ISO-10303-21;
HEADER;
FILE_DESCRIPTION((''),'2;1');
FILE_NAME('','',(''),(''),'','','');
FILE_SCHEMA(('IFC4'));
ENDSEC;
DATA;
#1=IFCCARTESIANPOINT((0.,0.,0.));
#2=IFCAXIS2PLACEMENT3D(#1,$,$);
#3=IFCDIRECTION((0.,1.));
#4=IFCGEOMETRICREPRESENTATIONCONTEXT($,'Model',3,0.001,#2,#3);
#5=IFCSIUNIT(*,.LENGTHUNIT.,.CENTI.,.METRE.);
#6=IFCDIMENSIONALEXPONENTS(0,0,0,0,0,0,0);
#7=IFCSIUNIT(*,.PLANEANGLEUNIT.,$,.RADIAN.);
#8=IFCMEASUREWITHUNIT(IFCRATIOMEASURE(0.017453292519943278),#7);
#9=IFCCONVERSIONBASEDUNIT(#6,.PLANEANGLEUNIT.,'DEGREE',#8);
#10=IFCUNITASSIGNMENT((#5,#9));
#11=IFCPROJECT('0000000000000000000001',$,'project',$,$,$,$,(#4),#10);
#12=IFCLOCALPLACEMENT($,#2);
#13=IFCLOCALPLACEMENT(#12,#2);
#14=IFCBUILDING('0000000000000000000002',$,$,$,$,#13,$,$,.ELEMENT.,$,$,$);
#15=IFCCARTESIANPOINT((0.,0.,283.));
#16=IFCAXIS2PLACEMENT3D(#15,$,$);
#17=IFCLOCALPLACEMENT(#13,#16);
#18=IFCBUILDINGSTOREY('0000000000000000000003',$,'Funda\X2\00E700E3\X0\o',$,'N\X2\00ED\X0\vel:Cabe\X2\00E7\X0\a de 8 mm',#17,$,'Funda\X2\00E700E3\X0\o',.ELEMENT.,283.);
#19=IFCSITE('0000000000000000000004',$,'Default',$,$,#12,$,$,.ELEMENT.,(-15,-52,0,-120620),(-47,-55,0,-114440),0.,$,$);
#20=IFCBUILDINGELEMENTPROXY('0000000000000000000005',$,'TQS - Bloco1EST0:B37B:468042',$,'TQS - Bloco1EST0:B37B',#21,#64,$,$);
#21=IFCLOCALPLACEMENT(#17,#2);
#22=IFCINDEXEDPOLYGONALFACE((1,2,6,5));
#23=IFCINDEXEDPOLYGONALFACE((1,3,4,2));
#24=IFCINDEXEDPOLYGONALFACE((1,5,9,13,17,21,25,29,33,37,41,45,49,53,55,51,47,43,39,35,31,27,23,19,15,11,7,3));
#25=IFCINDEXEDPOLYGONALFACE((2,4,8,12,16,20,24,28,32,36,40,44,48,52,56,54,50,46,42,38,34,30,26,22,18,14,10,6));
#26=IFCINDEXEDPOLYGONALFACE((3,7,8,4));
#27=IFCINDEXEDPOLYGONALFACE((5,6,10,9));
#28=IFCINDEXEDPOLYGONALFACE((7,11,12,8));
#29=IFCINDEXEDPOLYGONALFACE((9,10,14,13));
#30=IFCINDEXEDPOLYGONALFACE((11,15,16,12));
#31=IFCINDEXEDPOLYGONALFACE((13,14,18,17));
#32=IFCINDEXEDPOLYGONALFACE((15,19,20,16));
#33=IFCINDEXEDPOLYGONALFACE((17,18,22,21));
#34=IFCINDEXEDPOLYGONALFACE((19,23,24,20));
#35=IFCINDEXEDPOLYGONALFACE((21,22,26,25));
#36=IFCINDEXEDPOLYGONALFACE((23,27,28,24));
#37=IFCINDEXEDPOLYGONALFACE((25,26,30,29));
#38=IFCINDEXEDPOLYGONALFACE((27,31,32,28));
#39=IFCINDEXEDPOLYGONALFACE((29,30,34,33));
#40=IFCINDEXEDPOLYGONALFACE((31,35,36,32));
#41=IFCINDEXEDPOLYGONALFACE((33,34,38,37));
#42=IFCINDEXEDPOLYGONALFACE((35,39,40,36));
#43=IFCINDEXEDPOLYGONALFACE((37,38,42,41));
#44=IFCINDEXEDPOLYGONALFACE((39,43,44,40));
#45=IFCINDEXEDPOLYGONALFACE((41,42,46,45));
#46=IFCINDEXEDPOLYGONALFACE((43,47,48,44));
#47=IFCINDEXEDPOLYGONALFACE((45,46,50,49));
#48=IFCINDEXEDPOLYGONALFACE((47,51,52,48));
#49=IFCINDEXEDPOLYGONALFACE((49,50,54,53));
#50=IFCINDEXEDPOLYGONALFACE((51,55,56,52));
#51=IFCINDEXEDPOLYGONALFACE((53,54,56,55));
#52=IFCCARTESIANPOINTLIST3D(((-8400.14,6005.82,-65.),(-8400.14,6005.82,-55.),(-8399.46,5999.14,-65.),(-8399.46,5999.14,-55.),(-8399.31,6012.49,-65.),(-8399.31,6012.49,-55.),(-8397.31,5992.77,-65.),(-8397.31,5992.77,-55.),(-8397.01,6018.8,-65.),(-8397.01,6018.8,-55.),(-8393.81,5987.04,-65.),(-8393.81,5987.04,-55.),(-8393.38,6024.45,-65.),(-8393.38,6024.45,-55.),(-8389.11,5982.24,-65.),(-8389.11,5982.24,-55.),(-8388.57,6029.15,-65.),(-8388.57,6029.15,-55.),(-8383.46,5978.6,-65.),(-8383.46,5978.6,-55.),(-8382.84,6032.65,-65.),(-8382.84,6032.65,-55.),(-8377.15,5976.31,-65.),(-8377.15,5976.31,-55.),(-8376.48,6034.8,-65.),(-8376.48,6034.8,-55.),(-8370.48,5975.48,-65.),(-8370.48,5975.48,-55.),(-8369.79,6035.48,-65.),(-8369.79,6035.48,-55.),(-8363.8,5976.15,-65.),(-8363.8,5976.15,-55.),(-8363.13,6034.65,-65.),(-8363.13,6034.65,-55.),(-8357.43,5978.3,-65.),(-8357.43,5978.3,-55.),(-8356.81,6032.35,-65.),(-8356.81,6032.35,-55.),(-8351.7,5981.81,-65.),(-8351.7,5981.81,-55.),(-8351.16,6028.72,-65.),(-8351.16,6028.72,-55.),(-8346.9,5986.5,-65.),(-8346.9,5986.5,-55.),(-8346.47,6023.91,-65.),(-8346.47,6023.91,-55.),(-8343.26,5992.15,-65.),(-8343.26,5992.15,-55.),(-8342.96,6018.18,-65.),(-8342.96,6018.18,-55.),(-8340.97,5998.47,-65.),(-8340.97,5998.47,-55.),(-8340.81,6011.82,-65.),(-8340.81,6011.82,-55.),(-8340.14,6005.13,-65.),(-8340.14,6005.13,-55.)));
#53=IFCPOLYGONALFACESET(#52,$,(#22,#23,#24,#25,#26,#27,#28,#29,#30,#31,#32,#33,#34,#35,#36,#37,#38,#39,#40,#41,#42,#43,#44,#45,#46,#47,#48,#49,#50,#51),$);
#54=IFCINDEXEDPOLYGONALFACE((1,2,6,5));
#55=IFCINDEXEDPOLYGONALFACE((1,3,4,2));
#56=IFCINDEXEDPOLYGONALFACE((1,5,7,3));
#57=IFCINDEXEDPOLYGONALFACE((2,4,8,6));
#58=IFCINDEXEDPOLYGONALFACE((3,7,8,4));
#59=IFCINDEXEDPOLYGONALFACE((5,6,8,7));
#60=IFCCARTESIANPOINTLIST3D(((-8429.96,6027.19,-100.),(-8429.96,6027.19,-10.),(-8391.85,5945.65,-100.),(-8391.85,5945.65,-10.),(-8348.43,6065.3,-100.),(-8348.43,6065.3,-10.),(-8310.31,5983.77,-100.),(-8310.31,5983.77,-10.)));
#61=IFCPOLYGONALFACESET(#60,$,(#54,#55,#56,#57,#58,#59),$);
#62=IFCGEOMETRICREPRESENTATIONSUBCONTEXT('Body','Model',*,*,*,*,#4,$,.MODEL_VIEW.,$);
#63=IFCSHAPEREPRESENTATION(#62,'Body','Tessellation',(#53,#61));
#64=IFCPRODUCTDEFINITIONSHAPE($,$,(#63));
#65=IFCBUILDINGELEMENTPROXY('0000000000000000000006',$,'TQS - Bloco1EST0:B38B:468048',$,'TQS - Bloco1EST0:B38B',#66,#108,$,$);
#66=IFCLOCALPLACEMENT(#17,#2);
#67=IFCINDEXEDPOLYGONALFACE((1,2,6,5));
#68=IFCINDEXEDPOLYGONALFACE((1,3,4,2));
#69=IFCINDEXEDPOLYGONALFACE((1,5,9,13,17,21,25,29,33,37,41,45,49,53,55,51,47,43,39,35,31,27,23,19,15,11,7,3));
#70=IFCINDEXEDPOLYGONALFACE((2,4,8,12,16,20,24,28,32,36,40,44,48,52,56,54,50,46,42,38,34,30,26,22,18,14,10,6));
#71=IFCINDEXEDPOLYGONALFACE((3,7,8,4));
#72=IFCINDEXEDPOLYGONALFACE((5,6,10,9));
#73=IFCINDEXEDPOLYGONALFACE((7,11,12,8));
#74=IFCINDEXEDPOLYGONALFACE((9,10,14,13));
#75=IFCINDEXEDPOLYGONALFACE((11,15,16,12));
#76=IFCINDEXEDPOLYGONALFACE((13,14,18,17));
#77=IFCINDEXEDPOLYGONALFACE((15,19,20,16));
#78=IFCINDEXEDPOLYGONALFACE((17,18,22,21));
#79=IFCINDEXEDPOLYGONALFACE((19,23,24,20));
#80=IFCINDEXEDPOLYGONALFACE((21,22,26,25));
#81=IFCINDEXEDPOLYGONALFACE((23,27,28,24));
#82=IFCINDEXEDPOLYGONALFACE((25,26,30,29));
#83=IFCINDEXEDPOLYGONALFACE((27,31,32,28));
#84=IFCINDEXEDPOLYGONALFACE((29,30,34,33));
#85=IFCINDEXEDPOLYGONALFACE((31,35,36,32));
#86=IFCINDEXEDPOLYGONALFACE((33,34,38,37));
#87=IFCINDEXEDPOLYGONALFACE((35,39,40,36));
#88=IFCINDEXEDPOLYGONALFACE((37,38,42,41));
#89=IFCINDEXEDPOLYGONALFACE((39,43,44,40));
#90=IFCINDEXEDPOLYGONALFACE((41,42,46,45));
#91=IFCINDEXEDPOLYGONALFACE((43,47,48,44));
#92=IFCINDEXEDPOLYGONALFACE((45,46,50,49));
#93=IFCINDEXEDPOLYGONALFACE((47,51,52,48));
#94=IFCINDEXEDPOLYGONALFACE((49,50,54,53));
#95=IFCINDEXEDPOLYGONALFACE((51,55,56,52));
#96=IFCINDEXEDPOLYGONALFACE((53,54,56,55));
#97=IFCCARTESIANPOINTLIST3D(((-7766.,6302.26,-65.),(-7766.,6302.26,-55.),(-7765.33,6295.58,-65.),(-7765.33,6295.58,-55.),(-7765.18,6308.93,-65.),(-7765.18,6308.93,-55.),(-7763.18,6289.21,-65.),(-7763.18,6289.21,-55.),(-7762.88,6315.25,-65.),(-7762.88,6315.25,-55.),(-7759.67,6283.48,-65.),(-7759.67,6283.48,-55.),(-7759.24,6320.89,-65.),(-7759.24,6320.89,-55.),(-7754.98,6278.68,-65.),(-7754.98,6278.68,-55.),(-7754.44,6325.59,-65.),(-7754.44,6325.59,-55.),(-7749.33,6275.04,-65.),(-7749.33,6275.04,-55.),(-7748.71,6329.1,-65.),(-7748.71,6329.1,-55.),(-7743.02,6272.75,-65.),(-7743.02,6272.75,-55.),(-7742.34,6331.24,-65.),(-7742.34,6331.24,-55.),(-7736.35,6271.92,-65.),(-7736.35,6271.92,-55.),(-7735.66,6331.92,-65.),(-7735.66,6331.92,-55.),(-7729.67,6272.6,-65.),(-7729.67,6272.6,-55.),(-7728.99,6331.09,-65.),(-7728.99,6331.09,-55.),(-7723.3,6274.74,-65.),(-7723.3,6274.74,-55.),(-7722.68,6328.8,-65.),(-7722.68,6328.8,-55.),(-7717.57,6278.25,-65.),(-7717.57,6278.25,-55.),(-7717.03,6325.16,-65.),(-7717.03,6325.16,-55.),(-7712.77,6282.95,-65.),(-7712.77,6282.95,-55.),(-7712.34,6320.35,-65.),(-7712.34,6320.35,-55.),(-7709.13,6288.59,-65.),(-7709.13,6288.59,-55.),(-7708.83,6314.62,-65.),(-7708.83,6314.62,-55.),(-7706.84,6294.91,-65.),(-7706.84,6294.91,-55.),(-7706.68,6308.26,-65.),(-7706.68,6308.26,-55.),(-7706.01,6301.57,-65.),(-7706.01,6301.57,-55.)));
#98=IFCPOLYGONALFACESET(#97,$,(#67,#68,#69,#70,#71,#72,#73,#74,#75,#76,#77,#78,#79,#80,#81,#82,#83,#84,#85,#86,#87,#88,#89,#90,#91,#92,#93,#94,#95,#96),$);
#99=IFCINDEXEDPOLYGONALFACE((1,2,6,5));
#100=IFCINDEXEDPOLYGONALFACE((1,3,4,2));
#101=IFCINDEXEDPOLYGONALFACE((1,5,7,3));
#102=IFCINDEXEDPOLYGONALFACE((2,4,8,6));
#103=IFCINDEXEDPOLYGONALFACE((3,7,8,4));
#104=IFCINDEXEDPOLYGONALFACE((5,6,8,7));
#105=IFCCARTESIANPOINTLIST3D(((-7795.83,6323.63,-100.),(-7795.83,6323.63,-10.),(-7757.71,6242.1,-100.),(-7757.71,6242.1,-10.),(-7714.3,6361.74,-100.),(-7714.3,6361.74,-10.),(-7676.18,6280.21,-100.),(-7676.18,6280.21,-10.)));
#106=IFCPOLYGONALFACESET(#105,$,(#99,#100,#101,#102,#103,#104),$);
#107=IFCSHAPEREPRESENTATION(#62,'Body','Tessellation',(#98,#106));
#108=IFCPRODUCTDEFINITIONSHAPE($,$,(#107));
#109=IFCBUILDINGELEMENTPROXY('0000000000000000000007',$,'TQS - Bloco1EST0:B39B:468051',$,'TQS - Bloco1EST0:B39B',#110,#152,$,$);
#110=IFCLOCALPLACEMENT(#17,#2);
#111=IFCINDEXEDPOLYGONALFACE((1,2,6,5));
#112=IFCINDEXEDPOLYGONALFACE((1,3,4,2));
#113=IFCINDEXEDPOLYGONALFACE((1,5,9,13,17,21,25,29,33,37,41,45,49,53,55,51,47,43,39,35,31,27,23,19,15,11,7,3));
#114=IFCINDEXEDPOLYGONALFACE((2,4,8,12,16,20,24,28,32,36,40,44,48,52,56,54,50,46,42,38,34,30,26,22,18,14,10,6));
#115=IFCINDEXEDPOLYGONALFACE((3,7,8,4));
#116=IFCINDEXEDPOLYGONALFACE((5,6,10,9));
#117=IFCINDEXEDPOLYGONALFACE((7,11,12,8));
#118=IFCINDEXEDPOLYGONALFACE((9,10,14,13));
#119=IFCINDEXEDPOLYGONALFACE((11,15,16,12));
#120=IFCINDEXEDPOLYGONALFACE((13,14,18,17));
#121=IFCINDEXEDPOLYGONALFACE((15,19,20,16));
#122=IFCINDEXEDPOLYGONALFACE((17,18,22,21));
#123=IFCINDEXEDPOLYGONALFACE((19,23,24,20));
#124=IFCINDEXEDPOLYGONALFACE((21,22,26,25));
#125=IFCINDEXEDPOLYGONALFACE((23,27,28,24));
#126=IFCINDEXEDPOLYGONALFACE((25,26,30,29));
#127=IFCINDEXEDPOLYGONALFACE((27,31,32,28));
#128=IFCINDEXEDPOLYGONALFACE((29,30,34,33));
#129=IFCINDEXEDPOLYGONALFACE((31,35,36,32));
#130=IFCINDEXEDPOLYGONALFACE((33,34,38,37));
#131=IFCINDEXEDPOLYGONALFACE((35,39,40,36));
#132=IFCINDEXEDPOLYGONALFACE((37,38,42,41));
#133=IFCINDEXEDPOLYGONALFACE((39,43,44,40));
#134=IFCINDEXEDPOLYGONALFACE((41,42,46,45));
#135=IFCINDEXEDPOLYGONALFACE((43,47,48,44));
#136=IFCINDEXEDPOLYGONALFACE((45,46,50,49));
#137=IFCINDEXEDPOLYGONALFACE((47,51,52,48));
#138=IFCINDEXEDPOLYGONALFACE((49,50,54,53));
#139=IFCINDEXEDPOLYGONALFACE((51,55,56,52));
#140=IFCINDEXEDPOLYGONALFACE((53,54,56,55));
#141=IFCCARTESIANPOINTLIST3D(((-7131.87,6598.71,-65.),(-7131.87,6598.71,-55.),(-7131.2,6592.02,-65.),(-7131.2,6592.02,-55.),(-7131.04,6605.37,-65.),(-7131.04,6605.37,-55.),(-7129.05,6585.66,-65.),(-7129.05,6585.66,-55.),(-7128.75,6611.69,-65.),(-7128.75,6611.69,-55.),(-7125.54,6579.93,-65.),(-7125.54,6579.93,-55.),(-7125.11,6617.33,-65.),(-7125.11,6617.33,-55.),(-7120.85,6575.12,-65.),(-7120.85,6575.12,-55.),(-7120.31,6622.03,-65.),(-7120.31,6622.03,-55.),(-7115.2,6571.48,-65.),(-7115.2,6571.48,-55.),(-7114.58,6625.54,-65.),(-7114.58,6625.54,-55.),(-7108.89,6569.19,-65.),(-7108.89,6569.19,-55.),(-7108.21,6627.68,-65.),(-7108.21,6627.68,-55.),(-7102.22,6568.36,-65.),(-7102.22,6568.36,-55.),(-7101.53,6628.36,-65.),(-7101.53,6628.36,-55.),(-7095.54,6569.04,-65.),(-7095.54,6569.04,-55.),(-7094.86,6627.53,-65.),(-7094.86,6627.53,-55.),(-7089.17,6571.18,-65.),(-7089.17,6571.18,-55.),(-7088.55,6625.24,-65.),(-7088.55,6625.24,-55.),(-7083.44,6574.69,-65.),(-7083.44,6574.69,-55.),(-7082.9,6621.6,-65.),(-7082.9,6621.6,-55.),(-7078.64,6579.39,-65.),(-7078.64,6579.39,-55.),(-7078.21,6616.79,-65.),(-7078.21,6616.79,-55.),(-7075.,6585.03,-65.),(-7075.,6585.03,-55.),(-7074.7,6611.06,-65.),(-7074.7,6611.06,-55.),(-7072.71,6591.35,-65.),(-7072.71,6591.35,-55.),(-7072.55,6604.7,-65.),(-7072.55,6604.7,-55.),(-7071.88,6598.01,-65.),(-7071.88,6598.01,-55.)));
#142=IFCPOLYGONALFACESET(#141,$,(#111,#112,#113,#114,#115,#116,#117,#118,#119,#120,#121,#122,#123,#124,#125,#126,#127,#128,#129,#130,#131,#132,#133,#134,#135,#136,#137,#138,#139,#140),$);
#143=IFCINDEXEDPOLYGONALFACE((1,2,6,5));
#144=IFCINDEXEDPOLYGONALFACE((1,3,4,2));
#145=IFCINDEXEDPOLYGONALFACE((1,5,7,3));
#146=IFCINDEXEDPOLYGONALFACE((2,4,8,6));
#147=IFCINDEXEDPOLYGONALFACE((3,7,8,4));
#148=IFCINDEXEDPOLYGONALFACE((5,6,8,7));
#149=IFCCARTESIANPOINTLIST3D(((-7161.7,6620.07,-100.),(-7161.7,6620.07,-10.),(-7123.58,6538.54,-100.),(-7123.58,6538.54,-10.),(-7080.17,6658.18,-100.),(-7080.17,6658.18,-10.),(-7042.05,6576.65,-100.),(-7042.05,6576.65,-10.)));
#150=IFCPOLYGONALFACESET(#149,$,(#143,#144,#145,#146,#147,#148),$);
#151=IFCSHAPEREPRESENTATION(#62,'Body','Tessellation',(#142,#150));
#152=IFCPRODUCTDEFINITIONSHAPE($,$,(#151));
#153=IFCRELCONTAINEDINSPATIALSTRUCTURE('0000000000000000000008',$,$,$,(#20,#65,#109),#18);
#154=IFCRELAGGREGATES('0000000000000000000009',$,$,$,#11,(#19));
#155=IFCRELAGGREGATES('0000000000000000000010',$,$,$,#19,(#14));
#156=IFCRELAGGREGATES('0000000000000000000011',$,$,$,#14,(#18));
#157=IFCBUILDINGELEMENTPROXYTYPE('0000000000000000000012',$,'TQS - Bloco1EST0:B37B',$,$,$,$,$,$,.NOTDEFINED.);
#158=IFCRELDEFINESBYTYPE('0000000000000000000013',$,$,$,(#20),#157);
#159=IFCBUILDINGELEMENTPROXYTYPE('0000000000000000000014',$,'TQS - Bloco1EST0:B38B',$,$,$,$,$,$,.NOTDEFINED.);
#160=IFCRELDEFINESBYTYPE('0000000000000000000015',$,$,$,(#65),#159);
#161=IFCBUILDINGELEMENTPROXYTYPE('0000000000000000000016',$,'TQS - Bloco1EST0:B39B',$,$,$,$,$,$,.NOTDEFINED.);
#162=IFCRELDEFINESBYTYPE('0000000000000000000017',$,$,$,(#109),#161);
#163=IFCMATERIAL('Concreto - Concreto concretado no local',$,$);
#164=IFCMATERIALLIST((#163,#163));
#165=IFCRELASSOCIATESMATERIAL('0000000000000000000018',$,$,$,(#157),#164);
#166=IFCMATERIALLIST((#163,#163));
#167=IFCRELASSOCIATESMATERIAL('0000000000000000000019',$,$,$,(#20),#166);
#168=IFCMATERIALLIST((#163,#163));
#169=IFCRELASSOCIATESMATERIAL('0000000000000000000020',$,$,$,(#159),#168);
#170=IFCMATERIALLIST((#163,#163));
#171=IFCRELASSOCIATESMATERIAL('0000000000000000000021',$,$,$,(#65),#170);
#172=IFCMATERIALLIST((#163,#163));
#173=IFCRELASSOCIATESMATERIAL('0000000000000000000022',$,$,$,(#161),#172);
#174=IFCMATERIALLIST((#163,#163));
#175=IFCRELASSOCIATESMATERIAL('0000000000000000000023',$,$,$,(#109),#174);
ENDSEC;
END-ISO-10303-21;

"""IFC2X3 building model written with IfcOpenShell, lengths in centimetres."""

from ifc_helpers import new_model, entity, si_unit, converted_unit, direction, frame, frame_2d, origin, origin_2d_with_axis, place, context, subcontext, project, spatial, rectangle, circle, extrude, source, transform, mapped, material, material_list, type_object, type_shapes, element, save


model = new_model("IFC2X3")

# Units and contexts
model_context = context("Model", 3, precision=0.001, world=origin(), true_north=direction((0.0, 1.0)))
body_context = subcontext(model_context, "Body", "Model", "MODEL_VIEW")
ifc_project = project(units=[si_unit("LENGTHUNIT", "METRE", prefix="CENTI"), converted_unit("PLANEANGLEUNIT", "DEGREE", entity("IfcRatioMeasure", 0.017453292519943278), si_unit("PLANEANGLEUNIT", "RADIAN"), dimensions=[0, 0, 0, 0, 0, 0, 0])], contexts=[model_context])

# Site, building, storey
site_placement = place(None, origin())
site = spatial("IfcSite", under=ifc_project, at=site_placement, Name="Default", CompositionType="ELEMENT", RefLatitude=(-15, -52, 0, -120620), RefLongitude=(-47, -55, 0, -114440), RefElevation=0.0)
building_placement = place(site_placement, origin())
building = spatial("IfcBuilding", under=site, at=building_placement, CompositionType="ELEMENT")
storey_placement = place(building_placement, frame((0.0, 0.0, 283.0)))
storey = spatial("IfcBuildingStorey", under=building, at=storey_placement, Name="Fundação", ObjectType="Nível:Cabeça de 8 mm", LongName="Fundação", CompositionType="ELEMENT", Elevation=283.0)

# Building element proxies
ifc_material_1 = material(Name="Concreto - Concreto concretado no local")
ifc_material_list_1 = material_list([ifc_material_1, ifc_material_1])
ifc_material_list_2 = material_list([ifc_material_1, ifc_material_1])
building_element_proxy_type_1 = type_object("IfcBuildingElementProxyType", Name="TQS - Bloco1EST0:B37B", PredefinedType="NOTDEFINED", material=ifc_material_list_2)
shared_shape_1 = source(origin(), body_context, "Body", "SweptSolid", [
    extrude(circle(Radius=30.0, at=frame_2d((0.0, 0.0), x_axis=(1.0, 0.0))), frame((0.0, 0.0, -55.0)), (0.0, 0.0, 1.0), 10.0),
    extrude(rectangle(XDim=90.0, YDim=90.0, at=origin_2d_with_axis()), frame((0.0, 0.0, -90.0), z_axis=(0.0, 0.0, 1.0), x_axis=(-1.0, 0.0, 0.0)), (0.0, 0.0, 1.0), 90.0),
])
type_shapes(building_element_proxy_type_1, [shared_shape_1])
proxy_1_placement = place(storey_placement, frame((-8370.14, 6005.48, -10.0), z_axis=(0.0, 0.0, 1.0), x_axis=(0.905902, 0.423488, 0.0)))
element("IfcBuildingElementProxy", 1, at=proxy_1_placement, inside=storey, type_object=building_element_proxy_type_1, material=ifc_material_list_1, Name="TQS - Bloco1EST0:B37B:468042", ObjectType="TQS - Bloco1EST0:B37B", context=body_context, shape_type="MappedRepresentation", body=[
    mapped(shared_shape_1, transform((0.0, 0.0, 0.0), scale=1.0)),
])
ifc_material_list_3 = material_list([ifc_material_1, ifc_material_1])
ifc_material_list_4 = material_list([ifc_material_1, ifc_material_1])
building_element_proxy_type_2 = type_object("IfcBuildingElementProxyType", Name="TQS - Bloco1EST0:B38B", PredefinedType="NOTDEFINED", material=ifc_material_list_4)
shared_shape_2 = source(origin(), body_context, "Body", "SweptSolid", [
    extrude(circle(Radius=30.0, at=frame_2d((0.0, 0.0), x_axis=(1.0, 0.0))), frame((0.0, 0.0, -55.0)), (0.0, 0.0, 1.0), 10.0),
    extrude(rectangle(XDim=90.0, YDim=90.0, at=origin_2d_with_axis()), frame((0.0, 0.0, -90.0), z_axis=(0.0, 0.0, 1.0), x_axis=(-1.0, 0.0, 0.0)), (0.0, 0.0, 1.0), 90.0),
])
type_shapes(building_element_proxy_type_2, [shared_shape_2])
proxy_2_placement = place(storey_placement, frame((-7736.01, 6301.92, -10.0), z_axis=(0.0, 0.0, 1.0), x_axis=(0.905902, 0.423488, 0.0)))
element("IfcBuildingElementProxy", 2, at=proxy_2_placement, inside=storey, type_object=building_element_proxy_type_2, material=ifc_material_list_3, Name="TQS - Bloco1EST0:B38B:468048", ObjectType="TQS - Bloco1EST0:B38B", context=body_context, shape_type="MappedRepresentation", body=[
    mapped(shared_shape_2, transform((0.0, 0.0, 0.0), scale=1.0)),
])
ifc_material_list_5 = material_list([ifc_material_1, ifc_material_1])
ifc_material_list_6 = material_list([ifc_material_1, ifc_material_1])
building_element_proxy_type_3 = type_object("IfcBuildingElementProxyType", Name="TQS - Bloco1EST0:B39B", PredefinedType="NOTDEFINED", material=ifc_material_list_6)
shared_shape_3 = source(origin(), body_context, "Body", "SweptSolid", [
    extrude(circle(Radius=30.0, at=frame_2d((0.0, 0.0), x_axis=(1.0, 0.0))), frame((0.0, 0.0, -55.0)), (0.0, 0.0, 1.0), 10.0),
    extrude(rectangle(XDim=90.0, YDim=90.0, at=origin_2d_with_axis()), frame((0.0, 0.0, -90.0), z_axis=(0.0, 0.0, 1.0), x_axis=(-1.0, 0.0, 0.0)), (0.0, 0.0, 1.0), 90.0),
])
type_shapes(building_element_proxy_type_3, [shared_shape_3])
proxy_3_placement = place(storey_placement, frame((-7101.87, 6598.36, -10.0), z_axis=(0.0, 0.0, 1.0), x_axis=(0.905902, 0.423488, 0.0)))
element("IfcBuildingElementProxy", 3, at=proxy_3_placement, inside=storey, type_object=building_element_proxy_type_3, material=ifc_material_list_5, Name="TQS - Bloco1EST0:B39B:468051", ObjectType="TQS - Bloco1EST0:B39B", context=body_context, shape_type="MappedRepresentation", body=[
    mapped(shared_shape_3, transform((0.0, 0.0, 0.0), scale=1.0)),
])

save(model, "model.ifc")
